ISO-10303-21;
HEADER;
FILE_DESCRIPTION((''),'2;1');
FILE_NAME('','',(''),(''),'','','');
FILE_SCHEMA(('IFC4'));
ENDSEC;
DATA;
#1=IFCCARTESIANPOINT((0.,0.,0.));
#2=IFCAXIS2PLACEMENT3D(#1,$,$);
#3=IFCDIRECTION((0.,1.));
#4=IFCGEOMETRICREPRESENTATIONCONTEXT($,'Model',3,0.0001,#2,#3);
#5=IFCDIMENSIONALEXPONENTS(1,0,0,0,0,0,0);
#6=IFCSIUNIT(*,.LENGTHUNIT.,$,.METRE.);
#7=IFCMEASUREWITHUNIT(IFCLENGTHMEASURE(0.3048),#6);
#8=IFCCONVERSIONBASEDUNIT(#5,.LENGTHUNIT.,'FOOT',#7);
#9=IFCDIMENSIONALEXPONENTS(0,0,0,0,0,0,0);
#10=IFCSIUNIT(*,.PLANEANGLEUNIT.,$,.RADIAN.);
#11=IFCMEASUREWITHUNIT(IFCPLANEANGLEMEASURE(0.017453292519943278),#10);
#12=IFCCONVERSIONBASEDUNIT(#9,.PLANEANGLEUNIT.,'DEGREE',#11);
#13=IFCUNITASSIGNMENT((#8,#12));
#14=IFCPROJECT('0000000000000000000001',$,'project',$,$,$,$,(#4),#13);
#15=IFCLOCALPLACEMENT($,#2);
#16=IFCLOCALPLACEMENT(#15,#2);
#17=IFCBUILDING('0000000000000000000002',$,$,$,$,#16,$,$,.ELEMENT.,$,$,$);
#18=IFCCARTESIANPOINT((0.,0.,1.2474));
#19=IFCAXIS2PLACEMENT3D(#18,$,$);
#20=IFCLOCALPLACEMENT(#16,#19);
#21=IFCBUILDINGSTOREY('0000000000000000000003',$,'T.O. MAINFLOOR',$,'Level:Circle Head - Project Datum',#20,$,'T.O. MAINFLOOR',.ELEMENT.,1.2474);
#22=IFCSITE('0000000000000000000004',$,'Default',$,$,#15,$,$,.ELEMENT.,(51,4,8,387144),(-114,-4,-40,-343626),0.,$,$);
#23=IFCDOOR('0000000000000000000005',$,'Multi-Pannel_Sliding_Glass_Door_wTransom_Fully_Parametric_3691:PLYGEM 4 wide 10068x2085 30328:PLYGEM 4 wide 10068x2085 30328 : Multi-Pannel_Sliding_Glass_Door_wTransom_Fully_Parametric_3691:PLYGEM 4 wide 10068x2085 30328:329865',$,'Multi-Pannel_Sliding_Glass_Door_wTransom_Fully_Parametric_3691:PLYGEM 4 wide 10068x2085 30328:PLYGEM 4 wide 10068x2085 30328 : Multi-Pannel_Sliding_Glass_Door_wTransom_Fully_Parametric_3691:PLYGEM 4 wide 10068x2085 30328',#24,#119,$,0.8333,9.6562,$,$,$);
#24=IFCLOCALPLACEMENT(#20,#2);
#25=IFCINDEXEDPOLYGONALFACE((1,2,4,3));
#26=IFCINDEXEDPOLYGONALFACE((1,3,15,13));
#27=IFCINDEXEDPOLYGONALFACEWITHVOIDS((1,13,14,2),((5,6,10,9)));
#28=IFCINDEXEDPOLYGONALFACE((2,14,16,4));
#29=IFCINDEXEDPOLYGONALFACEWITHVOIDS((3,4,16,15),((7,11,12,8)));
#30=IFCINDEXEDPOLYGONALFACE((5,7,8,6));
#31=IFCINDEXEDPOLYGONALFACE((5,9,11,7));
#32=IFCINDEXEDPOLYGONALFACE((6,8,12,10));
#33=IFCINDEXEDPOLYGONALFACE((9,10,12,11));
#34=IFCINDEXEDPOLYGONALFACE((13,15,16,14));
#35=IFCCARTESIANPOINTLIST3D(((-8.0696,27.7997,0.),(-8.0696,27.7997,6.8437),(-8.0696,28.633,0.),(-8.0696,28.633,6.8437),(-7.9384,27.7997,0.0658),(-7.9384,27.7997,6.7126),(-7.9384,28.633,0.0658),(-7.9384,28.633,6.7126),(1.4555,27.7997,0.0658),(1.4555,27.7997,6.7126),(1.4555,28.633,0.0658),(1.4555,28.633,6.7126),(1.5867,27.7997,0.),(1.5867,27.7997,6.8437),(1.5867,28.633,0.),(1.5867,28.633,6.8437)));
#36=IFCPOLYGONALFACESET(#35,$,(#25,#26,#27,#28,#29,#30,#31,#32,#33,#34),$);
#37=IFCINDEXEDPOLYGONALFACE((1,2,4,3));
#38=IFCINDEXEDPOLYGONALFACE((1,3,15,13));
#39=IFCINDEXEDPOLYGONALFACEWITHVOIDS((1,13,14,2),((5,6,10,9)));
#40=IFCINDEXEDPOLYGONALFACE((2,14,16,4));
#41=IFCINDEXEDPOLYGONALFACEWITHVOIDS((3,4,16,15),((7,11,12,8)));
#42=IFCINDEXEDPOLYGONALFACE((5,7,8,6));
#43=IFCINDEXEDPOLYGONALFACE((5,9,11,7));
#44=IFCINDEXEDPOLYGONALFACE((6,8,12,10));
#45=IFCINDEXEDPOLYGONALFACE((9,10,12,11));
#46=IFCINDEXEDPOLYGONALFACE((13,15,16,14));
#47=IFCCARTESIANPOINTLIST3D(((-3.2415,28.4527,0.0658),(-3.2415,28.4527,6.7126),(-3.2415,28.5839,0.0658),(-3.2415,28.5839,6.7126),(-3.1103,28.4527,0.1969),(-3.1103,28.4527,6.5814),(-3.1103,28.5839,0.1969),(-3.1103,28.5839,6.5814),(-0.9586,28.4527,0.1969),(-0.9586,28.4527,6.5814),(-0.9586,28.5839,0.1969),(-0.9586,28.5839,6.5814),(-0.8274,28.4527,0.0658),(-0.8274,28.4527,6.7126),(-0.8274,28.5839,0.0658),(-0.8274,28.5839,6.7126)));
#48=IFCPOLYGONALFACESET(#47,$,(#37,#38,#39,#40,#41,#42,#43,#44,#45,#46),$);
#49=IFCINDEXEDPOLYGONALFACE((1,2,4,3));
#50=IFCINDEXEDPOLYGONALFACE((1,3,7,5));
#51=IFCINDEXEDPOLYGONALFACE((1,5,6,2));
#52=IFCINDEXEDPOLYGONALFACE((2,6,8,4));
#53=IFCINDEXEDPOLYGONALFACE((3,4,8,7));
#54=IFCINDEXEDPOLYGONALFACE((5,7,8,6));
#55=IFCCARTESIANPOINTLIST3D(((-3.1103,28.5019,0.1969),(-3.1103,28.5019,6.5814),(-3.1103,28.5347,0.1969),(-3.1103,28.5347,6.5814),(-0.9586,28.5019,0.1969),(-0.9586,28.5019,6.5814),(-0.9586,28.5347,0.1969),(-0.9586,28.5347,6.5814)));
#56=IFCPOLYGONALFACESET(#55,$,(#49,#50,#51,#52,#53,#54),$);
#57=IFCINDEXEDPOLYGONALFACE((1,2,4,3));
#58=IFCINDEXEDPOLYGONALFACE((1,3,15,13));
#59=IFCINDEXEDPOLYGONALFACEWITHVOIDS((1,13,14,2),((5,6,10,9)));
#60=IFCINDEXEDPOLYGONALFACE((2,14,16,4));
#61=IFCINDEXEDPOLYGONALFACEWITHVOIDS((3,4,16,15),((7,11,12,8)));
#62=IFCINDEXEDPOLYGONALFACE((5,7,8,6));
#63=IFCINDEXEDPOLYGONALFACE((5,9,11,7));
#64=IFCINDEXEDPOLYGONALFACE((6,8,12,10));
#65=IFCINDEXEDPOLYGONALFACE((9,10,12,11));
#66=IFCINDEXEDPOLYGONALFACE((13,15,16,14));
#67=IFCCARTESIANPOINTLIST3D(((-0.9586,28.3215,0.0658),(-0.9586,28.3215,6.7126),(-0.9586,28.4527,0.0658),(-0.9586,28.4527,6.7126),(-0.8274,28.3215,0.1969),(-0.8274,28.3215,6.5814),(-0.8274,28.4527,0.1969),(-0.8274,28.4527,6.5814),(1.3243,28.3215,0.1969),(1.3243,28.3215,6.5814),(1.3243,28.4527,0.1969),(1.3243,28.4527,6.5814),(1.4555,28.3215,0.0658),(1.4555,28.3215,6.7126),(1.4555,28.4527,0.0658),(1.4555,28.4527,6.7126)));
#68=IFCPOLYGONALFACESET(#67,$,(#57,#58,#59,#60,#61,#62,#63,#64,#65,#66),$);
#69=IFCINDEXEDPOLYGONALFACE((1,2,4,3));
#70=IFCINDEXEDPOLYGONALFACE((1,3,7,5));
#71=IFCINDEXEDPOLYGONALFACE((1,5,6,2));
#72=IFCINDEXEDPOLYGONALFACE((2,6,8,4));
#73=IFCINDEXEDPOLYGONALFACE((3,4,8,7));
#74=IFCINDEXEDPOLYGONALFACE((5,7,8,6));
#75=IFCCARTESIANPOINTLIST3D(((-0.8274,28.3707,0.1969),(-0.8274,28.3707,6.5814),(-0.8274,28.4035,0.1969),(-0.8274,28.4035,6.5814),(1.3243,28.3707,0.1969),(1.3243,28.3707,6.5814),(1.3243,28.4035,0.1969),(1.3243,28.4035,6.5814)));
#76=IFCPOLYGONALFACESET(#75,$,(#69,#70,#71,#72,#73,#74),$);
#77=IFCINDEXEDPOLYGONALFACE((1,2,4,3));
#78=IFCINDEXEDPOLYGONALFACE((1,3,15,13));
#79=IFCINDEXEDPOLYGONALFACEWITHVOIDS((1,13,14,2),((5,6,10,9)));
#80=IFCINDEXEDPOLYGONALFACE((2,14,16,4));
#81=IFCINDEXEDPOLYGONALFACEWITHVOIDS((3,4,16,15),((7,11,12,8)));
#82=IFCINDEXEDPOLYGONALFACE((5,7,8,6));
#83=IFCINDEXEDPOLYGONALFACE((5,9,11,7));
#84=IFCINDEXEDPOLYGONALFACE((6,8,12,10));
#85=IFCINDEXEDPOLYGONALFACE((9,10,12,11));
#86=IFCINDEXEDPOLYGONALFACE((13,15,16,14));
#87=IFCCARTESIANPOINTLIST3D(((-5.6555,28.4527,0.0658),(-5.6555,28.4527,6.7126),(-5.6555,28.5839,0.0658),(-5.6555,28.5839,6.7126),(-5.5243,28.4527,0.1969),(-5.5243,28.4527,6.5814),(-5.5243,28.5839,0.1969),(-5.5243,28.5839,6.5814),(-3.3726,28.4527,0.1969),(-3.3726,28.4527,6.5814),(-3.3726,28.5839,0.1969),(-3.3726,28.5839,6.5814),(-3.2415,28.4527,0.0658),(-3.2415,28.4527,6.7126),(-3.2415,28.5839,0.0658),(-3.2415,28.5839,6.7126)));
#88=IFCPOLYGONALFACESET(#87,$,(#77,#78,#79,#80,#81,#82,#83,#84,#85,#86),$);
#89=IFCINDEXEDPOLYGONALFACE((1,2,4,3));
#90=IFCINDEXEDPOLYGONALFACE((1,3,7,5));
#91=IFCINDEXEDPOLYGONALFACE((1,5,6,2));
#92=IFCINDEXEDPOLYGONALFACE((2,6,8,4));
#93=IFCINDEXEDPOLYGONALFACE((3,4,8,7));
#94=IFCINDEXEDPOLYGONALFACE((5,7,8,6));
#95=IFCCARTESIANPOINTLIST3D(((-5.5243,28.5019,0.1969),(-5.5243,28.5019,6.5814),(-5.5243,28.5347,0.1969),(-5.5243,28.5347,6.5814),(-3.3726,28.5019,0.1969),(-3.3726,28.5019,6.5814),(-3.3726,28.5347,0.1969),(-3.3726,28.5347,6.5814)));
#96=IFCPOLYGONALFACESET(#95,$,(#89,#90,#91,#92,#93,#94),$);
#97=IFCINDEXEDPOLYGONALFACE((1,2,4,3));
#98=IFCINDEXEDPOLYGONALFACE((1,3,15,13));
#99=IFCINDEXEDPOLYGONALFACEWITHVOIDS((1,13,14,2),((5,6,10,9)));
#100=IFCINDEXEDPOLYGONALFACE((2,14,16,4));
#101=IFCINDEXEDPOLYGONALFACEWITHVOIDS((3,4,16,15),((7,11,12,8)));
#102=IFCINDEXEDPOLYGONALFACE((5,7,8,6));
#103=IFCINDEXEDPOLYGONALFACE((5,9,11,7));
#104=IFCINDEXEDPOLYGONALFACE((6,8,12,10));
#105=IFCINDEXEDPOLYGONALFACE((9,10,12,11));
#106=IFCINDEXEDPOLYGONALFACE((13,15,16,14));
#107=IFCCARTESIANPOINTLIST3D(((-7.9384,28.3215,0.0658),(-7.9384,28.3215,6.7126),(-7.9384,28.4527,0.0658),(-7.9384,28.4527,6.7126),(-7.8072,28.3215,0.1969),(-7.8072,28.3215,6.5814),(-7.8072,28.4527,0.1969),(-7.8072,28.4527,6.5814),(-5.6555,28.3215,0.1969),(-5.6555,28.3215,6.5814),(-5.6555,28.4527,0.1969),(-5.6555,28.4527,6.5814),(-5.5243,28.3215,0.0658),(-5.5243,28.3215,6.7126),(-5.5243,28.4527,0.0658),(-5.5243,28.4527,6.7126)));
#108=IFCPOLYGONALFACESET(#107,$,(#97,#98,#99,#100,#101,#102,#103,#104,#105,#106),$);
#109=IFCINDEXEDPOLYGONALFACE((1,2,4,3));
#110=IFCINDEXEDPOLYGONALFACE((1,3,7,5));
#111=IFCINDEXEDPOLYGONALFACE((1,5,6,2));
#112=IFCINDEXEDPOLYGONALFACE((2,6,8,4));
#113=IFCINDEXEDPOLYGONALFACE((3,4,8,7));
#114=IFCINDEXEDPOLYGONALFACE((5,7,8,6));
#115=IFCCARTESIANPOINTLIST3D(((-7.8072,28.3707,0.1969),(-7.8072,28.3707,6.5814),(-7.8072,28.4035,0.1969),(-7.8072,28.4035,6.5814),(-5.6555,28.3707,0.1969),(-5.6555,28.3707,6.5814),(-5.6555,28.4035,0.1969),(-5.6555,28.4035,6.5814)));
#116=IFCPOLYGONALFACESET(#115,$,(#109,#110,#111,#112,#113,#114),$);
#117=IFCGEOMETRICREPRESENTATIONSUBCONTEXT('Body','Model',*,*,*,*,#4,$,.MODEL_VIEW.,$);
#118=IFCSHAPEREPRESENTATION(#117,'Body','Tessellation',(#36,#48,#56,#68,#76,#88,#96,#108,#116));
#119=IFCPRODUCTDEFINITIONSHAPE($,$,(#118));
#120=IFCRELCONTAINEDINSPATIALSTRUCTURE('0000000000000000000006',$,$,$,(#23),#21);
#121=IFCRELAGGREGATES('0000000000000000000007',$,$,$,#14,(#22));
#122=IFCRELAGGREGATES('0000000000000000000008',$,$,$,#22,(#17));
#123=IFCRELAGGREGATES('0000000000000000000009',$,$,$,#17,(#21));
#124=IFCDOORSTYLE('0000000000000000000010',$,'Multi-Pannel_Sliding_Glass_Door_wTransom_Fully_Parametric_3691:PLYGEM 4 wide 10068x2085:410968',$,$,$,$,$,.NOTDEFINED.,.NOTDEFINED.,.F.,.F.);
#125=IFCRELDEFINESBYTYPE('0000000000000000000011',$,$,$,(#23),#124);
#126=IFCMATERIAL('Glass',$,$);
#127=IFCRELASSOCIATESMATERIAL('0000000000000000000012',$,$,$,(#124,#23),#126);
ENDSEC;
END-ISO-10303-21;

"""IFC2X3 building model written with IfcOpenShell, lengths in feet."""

from ifc_helpers import new_model, entity, si_unit, converted_unit, direction, frame, frame_2d, origin, origin_2d_with_axis, place, context, subcontext, project, spatial, polyline, rectangle, outline, extrude, source, transform, mapped, material, type_object, type_shapes, element, save


model = new_model("IFC2X3")

# Units and contexts
model_context = context("Model", 3, precision=0.0001, world=origin(), true_north=direction((0.0, 1.0)))
body_context = subcontext(model_context, "Body", "Model", "MODEL_VIEW")
ifc_project = project(units=[converted_unit("LENGTHUNIT", "FOOT", entity("IfcLengthMeasure", 0.3048), si_unit("LENGTHUNIT", "METRE"), dimensions=[1, 0, 0, 0, 0, 0, 0]), converted_unit("PLANEANGLEUNIT", "DEGREE", entity("IfcPlaneAngleMeasure", 0.017453292519943278), si_unit("PLANEANGLEUNIT", "RADIAN"), dimensions=[0, 0, 0, 0, 0, 0, 0])], contexts=[model_context])

# Site, building, storey
site_placement = place(None, origin())
site = spatial("IfcSite", under=ifc_project, at=site_placement, Name="Default", CompositionType="ELEMENT", RefLatitude=(51, 4, 8, 387144), RefLongitude=(-114, -4, -40, -343626), RefElevation=0.0)
building_placement = place(site_placement, origin())
building = spatial("IfcBuilding", under=site, at=building_placement, CompositionType="ELEMENT")
storey_placement = place(building_placement, frame((0.0, 0.0, 1.2474)))
storey = spatial("IfcBuildingStorey", under=building, at=storey_placement, Name="T.O. MAINFLOOR", ObjectType="Level:Circle Head - Project Datum", LongName="T.O. MAINFLOOR", CompositionType="ELEMENT", Elevation=1.2474)

# Door
ifc_material_1 = material(Name="Glass")
door_style_1 = type_object("IfcDoorStyle", Name="Multi-Pannel_Sliding_Glass_Door_wTransom_Fully_Parametric_3691:PLYGEM 4 wide 10068x2085:410968", ConstructionType="NOTDEFINED", OperationType="NOTDEFINED", ParameterTakesPrecedence=False, Sizeable=False, material=ifc_material_1)
shared_shape_1 = source(origin(), body_context, "Body", "SweptSolid", [
    extrude(outline(polyline([(-3.4219, -4.8281), (3.4219, -4.8281), (3.4219, 4.8281), (-3.4219, 4.8281), (-3.4219, -4.8281)]), holes=[polyline([(-3.2907, 4.6969), (3.3561, 4.6969), (3.3561, -4.6969), (-3.2907, -4.6969), (-3.2907, 4.6969)])]), frame((-3.2415, 27.7997, 4.6693), z_axis=(0.0, 1.0, 0.0), x_axis=(0.0, 0.0, -1.0)), (0.0, 0.0, 1.0), 0.8333),
    extrude(outline(polyline([(-3.3234, -1.207), (3.3234, -1.207), (3.3234, 1.207), (-3.3234, 1.207), (-3.3234, -1.207)]), holes=[polyline([(3.1922, -1.0758), (-3.1922, -1.0758), (-3.1922, 1.0758), (3.1922, 1.0758), (3.1922, -1.0758)])]), frame((-2.0344, 28.4527, 4.6366), z_axis=(0.0, 1.0, 0.0), x_axis=(0.0, 0.0, 1.0)), (0.0, 0.0, 1.0), 0.1312),
    extrude(rectangle(XDim=0.0328, YDim=2.1517, at=frame_2d((0.0, 0.0), x_axis=(1.0, 0.0))), frame((-2.0344, 28.5183, 1.4443), z_axis=(0.0, 0.0, 1.0), x_axis=(0.0, 1.0, 0.0)), (0.0, 0.0, 1.0), 6.3844),
    extrude(outline(polyline([(-3.3234, -1.207), (3.3234, -1.207), (3.3234, 1.207), (-3.3234, 1.207), (-3.3234, -1.207)]), holes=[polyline([(3.1922, -1.0758), (-3.1922, -1.0758), (-3.1922, 1.0758), (3.1922, 1.0758), (3.1922, -1.0758)])]), frame((0.2484, 28.3215, 4.6366), z_axis=(0.0, 1.0, 0.0), x_axis=(0.0, 0.0, 1.0)), (0.0, 0.0, 1.0), 0.1312),
    extrude(rectangle(XDim=0.0328, YDim=2.1517, at=origin_2d_with_axis()), frame((0.2484, 28.3871, 1.4443), z_axis=(0.0, 0.0, 1.0), x_axis=(0.0, 1.0, 0.0)), (0.0, 0.0, 1.0), 6.3844),
    extrude(outline(polyline([(-3.3234, -1.207), (3.3234, -1.207), (3.3234, 1.207), (-3.3234, 1.207), (-3.3234, -1.207)]), holes=[polyline([(3.1922, -1.0758), (-3.1922, -1.0758), (-3.1922, 1.0758), (3.1922, 1.0758), (3.1922, -1.0758)])]), frame((-4.4485, 28.4527, 4.6366), z_axis=(0.0, 1.0, 0.0), x_axis=(0.0, 0.0, 1.0)), (0.0, 0.0, 1.0), 0.1312),
    extrude(rectangle(XDim=0.0328, YDim=2.1517, at=frame_2d((0.0, 0.0), x_axis=(1.0, 0.0))), frame((-4.4485, 28.5183, 1.4443), z_axis=(0.0, 0.0, 1.0), x_axis=(0.0, 1.0, 0.0)), (0.0, 0.0, 1.0), 6.3844),
    extrude(outline(polyline([(-3.3234, -1.207), (3.3234, -1.207), (3.3234, 1.207), (-3.3234, 1.207), (-3.3234, -1.207)]), holes=[polyline([(3.1922, -1.0758), (-3.1922, -1.0758), (-3.1922, 1.0758), (3.1922, 1.0758), (3.1922, -1.0758)])]), frame((-6.7314, 28.3215, 4.6366), z_axis=(0.0, 1.0, 0.0), x_axis=(0.0, 0.0, 1.0)), (0.0, 0.0, 1.0), 0.1312),
    extrude(rectangle(XDim=0.0328, YDim=2.1517, at=frame_2d((0.0, 0.0), x_axis=(1.0, 0.0))), frame((-6.7314, 28.3871, 1.4443), z_axis=(0.0, 0.0, 1.0), x_axis=(0.0, 1.0, 0.0)), (0.0, 0.0, 1.0), 6.3844),
])
type_shapes(door_style_1, [shared_shape_1])
door_1_placement = place(storey_placement, frame((0.0, 0.0, -1.2474)))
element("IfcDoor", 1, at=door_1_placement, inside=storey, type_object=door_style_1, material=ifc_material_1, Name="Multi-Pannel_Sliding_Glass_Door_wTransom_Fully_Parametric_3691:PLYGEM 4 wide 10068x2085 30328:PLYGEM 4 wide 10068x2085 30328 : Multi-Pannel_Sliding_Glass_Door_wTransom_Fully_Parametric_3691:PLYGEM 4 wide 10068x2085 30328:329865", ObjectType="Multi-Pannel_Sliding_Glass_Door_wTransom_Fully_Parametric_3691:PLYGEM 4 wide 10068x2085 30328:PLYGEM 4 wide 10068x2085 30328 : Multi-Pannel_Sliding_Glass_Door_wTransom_Fully_Parametric_3691:PLYGEM 4 wide 10068x2085 30328", OverallHeight=0.8333, OverallWidth=9.6562, context=body_context, shape_type="MappedRepresentation", body=[
    mapped(shared_shape_1, transform((0.0, 0.0, 0.0), scale=1.0)),
])

save(model, "model.ifc")
